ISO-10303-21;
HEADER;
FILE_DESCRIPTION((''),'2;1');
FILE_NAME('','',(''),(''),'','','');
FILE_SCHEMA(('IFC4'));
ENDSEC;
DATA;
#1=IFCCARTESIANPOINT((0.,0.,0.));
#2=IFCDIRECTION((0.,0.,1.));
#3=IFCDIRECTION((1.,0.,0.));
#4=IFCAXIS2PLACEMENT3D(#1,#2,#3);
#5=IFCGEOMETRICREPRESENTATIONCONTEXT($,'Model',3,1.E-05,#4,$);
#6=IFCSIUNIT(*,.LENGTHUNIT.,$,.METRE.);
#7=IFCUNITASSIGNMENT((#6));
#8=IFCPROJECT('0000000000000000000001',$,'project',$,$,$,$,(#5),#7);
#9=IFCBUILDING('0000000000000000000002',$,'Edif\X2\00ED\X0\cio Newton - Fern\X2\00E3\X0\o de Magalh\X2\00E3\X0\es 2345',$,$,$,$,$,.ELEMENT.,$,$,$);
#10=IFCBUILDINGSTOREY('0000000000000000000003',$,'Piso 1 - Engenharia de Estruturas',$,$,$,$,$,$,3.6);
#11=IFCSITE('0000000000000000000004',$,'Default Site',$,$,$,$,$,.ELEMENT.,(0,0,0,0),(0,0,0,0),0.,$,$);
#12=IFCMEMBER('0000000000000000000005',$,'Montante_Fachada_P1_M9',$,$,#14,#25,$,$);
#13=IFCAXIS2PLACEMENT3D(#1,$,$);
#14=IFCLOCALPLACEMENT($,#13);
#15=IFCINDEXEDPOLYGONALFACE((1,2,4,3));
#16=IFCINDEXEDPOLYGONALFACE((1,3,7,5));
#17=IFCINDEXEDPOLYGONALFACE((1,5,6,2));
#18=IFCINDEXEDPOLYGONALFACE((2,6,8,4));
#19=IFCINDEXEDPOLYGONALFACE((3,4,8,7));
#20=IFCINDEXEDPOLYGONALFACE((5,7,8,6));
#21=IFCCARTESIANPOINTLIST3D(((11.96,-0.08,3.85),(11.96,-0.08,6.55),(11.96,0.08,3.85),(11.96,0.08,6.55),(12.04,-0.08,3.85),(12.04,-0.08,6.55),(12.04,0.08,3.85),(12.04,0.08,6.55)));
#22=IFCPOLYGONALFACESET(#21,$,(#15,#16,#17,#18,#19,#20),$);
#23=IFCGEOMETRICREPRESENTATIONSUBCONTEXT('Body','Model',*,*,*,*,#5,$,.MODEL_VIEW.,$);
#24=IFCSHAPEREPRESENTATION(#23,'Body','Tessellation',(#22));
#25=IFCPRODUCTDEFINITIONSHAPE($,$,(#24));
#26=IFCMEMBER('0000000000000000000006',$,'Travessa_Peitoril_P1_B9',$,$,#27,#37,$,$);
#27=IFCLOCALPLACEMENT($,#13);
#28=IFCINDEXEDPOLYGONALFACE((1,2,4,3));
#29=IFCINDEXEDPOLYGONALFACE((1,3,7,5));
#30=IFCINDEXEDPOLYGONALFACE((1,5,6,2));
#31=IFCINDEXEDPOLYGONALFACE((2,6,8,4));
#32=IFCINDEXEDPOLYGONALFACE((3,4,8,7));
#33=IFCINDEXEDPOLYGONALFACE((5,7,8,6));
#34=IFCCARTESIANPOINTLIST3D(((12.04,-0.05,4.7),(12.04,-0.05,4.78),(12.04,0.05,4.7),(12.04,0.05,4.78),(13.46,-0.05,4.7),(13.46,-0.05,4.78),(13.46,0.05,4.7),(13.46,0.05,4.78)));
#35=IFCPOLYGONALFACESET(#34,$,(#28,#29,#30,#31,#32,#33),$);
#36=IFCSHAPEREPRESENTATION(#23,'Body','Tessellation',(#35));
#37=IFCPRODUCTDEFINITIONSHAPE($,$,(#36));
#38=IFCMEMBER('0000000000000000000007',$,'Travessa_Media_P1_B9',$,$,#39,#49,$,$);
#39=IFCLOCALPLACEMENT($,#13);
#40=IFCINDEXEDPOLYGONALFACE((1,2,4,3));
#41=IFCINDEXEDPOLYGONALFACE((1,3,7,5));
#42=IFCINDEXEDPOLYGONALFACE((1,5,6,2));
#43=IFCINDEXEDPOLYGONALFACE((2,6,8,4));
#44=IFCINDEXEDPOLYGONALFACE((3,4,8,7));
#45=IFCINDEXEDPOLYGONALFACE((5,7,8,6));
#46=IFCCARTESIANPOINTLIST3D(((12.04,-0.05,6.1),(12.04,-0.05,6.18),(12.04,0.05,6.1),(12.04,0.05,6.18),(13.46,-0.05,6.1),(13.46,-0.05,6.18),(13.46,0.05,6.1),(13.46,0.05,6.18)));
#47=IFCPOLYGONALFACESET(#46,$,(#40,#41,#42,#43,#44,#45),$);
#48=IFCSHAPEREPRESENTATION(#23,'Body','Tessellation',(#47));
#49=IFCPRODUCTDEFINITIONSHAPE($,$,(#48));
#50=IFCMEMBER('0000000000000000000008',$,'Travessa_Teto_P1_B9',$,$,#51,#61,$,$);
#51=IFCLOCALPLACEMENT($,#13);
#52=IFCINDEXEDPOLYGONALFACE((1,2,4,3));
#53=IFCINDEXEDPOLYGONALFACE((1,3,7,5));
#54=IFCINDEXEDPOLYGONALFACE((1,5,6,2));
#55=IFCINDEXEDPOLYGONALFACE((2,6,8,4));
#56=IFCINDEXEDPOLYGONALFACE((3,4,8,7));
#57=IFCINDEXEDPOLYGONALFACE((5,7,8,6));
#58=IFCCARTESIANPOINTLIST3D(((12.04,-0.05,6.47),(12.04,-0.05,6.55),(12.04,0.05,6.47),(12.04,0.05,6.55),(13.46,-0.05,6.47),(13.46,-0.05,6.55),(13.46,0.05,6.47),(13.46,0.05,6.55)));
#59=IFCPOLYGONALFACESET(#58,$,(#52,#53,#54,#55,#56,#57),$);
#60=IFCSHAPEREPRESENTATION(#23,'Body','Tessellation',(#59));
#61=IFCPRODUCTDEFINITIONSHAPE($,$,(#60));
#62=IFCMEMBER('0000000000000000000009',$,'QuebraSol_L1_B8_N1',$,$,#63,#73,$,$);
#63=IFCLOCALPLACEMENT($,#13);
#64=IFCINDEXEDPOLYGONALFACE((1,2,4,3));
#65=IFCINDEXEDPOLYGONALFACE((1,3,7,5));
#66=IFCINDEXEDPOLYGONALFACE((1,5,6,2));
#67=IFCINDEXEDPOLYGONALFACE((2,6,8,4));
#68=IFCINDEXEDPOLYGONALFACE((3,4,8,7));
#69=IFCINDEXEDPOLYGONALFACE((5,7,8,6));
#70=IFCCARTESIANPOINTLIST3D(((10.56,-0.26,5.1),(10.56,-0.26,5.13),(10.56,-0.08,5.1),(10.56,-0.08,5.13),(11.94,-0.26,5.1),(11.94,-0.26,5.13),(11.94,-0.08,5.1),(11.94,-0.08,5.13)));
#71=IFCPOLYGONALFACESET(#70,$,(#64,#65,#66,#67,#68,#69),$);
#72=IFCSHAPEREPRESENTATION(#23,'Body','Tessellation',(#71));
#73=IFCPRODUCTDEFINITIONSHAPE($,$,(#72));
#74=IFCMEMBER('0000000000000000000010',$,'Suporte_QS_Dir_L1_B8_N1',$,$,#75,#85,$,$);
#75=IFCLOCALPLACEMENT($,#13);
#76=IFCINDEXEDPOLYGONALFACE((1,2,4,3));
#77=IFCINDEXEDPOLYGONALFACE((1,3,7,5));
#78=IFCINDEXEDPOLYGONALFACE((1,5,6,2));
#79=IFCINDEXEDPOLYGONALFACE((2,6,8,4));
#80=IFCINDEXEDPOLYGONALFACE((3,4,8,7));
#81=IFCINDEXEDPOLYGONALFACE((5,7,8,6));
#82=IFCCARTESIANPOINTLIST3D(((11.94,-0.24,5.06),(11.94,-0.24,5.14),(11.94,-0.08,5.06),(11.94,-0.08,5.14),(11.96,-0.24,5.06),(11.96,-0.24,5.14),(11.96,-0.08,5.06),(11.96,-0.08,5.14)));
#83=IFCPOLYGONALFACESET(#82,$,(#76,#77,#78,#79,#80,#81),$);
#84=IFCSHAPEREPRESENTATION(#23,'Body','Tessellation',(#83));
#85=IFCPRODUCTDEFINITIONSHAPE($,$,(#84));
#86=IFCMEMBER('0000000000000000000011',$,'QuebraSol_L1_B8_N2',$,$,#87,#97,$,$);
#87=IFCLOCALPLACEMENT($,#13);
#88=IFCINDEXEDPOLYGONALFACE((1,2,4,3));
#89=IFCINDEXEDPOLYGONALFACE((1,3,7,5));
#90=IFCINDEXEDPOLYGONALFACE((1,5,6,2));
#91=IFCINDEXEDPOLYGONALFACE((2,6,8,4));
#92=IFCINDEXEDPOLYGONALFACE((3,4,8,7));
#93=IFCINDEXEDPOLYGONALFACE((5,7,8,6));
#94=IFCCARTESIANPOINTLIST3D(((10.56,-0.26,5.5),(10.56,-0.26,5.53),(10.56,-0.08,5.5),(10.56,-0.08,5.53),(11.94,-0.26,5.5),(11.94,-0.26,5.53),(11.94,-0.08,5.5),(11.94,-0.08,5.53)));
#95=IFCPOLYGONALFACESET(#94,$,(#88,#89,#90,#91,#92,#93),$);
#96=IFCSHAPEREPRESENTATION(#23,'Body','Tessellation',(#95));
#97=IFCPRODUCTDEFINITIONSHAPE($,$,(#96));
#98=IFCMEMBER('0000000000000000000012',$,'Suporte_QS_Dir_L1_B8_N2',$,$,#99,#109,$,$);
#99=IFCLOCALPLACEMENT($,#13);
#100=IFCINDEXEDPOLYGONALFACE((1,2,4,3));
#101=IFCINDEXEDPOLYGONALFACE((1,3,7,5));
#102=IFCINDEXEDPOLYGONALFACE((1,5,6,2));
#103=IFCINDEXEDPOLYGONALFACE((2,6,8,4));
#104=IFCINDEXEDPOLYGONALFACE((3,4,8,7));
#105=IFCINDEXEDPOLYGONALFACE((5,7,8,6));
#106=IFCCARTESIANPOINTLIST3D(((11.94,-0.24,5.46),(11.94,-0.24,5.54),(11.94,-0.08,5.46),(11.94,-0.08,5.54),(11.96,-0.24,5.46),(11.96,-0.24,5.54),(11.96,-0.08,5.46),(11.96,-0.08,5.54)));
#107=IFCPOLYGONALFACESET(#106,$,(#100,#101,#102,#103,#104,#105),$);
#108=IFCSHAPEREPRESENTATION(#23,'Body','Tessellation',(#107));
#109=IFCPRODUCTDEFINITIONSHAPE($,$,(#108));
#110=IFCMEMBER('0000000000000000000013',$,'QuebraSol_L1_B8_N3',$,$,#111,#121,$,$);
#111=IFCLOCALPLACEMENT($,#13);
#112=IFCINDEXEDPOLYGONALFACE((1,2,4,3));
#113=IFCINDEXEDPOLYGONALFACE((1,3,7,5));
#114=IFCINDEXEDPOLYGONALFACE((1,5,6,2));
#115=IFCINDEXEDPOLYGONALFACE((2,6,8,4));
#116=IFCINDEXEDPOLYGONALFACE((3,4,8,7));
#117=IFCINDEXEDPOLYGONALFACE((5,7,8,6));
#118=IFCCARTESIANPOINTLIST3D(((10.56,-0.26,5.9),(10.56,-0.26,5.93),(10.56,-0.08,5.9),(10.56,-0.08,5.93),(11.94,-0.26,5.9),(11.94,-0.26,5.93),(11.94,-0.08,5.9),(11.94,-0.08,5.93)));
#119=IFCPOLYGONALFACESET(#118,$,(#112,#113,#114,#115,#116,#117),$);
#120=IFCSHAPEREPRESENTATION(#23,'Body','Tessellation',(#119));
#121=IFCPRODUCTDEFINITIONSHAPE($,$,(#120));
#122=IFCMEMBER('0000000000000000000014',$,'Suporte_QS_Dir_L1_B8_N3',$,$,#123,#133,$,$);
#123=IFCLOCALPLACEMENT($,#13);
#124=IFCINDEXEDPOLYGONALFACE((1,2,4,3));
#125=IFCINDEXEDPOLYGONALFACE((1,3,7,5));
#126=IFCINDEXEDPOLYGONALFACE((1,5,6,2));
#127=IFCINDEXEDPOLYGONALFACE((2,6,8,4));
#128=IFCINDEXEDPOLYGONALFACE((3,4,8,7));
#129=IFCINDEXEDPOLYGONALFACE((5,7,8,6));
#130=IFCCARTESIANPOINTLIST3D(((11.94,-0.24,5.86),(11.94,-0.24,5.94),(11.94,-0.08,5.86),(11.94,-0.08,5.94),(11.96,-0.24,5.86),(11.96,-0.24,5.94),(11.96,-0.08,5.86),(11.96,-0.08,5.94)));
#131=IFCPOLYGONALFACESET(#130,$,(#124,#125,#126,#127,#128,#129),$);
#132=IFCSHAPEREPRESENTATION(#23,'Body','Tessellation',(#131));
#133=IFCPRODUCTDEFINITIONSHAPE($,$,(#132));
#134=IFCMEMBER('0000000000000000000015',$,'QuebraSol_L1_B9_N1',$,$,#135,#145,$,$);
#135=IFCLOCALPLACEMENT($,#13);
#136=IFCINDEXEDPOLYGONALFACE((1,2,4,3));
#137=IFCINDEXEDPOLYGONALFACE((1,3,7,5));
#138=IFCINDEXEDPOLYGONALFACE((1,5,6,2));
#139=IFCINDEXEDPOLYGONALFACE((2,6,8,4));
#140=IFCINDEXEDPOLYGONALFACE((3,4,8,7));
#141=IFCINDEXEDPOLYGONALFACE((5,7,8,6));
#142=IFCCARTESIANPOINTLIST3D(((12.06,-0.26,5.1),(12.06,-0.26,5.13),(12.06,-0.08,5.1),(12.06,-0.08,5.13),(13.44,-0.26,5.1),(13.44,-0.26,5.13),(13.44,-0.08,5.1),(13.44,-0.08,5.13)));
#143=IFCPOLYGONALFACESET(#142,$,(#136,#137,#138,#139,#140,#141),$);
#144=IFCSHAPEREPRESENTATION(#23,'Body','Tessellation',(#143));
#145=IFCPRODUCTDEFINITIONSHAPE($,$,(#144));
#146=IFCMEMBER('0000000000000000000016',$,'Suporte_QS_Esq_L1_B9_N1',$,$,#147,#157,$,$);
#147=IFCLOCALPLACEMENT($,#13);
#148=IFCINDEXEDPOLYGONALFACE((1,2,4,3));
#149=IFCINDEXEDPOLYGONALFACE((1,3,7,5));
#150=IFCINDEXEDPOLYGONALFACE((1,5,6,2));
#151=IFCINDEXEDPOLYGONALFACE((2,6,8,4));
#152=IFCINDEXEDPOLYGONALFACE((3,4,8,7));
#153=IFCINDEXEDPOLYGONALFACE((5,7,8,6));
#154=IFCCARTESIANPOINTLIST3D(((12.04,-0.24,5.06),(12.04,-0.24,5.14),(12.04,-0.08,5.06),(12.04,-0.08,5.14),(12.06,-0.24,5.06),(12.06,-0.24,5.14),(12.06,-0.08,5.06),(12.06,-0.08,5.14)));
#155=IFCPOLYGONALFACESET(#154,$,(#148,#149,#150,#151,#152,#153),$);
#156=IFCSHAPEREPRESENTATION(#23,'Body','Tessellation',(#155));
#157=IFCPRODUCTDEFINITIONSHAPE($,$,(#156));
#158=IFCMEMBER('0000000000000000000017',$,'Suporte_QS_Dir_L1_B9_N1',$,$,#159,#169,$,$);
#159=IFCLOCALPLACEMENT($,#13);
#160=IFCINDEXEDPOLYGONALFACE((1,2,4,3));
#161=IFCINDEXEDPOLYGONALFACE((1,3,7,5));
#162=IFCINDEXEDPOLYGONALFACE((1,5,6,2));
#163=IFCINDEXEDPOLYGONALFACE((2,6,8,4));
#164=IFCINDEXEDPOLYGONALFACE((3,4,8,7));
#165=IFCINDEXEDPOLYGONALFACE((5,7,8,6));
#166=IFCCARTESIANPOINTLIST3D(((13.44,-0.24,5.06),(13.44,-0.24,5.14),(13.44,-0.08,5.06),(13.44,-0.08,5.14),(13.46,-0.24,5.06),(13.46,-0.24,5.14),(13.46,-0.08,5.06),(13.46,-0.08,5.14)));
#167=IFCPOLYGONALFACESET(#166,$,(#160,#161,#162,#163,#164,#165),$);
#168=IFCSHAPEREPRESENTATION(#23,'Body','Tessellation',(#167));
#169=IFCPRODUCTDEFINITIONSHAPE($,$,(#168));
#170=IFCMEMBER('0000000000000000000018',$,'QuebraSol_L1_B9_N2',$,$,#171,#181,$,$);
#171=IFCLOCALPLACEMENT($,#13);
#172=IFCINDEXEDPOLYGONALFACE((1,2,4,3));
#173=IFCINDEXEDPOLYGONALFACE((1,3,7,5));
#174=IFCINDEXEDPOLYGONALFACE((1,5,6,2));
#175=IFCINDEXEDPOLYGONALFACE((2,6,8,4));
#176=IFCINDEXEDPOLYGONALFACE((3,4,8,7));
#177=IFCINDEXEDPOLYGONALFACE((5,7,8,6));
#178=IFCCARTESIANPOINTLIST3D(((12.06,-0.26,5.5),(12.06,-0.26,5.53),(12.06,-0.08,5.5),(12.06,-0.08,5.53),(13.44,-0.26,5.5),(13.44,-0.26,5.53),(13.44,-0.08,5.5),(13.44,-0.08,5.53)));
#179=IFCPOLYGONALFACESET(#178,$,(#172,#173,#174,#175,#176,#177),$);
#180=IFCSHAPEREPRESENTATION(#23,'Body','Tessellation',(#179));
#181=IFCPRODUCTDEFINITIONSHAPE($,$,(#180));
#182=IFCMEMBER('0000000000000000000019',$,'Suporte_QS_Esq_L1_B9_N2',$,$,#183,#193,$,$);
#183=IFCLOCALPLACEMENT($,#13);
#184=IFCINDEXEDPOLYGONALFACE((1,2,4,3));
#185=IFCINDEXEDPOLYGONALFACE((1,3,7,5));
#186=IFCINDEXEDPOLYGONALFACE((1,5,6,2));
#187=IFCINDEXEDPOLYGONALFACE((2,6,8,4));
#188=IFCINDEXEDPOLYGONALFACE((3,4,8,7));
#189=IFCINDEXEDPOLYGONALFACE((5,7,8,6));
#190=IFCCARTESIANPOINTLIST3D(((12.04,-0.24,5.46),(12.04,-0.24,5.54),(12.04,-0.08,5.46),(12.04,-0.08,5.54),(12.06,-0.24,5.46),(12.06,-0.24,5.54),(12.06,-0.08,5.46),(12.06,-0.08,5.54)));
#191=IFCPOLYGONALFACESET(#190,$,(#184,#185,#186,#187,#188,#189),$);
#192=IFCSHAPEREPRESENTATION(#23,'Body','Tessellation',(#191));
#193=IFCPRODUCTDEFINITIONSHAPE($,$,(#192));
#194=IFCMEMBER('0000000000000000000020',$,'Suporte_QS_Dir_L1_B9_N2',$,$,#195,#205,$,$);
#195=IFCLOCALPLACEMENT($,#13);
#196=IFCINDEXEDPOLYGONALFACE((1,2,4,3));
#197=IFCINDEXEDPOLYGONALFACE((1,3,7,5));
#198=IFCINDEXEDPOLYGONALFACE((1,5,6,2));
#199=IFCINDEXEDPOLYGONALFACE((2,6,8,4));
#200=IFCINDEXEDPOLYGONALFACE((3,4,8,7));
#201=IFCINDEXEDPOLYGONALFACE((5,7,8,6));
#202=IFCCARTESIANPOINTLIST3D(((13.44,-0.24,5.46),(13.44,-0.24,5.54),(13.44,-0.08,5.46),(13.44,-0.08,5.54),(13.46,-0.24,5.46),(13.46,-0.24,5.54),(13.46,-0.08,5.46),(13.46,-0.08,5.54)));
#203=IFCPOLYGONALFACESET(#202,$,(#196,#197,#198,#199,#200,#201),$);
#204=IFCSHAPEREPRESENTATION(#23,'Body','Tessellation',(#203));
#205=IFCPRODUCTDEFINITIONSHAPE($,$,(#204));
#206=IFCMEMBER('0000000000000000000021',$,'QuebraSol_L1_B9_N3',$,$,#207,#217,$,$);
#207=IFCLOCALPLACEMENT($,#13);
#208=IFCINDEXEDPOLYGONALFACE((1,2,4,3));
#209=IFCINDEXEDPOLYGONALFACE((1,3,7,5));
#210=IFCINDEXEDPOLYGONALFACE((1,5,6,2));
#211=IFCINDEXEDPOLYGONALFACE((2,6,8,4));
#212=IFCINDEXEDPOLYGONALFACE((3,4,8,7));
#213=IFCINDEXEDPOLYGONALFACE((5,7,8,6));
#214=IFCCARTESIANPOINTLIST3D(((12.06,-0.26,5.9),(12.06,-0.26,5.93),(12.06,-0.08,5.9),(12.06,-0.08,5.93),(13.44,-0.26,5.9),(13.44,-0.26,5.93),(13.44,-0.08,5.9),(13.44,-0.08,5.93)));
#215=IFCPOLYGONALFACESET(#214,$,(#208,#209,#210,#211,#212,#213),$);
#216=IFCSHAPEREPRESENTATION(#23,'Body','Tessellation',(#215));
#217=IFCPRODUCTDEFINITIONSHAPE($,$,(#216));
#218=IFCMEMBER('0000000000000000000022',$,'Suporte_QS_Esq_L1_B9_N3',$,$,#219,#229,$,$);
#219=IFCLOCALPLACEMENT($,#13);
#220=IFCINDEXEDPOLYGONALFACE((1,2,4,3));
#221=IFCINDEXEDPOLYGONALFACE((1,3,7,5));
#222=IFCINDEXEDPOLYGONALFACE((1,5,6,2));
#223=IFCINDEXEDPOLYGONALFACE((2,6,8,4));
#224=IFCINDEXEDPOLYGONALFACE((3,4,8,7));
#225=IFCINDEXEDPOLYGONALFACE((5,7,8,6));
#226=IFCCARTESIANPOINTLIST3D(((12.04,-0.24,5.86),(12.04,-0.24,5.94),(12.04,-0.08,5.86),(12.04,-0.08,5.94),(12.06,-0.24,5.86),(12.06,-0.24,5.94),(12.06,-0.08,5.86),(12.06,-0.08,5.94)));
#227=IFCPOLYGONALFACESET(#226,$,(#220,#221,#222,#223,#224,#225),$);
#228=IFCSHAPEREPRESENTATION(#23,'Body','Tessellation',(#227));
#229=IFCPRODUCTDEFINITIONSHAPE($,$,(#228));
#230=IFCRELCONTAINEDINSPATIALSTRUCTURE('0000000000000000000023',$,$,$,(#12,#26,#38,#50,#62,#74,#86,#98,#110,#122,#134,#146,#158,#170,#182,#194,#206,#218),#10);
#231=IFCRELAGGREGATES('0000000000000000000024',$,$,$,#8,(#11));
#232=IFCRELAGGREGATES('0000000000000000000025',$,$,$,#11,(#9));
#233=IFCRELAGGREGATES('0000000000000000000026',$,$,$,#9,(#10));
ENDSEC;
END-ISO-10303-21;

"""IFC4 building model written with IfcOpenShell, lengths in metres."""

from ifc_helpers import new_model, si_unit, frame, frame_2d, origin_with_axes, place, context, subcontext, project, spatial, rectangle, extrude, element, save


model = new_model("IFC4")

# Units and contexts
model_context = context("Model", 3, precision=1e-05, world=origin_with_axes())
body_context = subcontext(model_context, "Body", "Model", "MODEL_VIEW")
ifc_project = project(units=[si_unit("LENGTHUNIT", "METRE")], contexts=[model_context])

# Site, building, storey
site = spatial("IfcSite", under=ifc_project, Name="Default Site", CompositionType="ELEMENT", RefLatitude=(0, 0, 0, 0), RefLongitude=(0, 0, 0, 0), RefElevation=0.0)
building = spatial("IfcBuilding", under=site, Name="Edifício Newton - Fernão de Magalhães 2345", CompositionType="ELEMENT")
storey = spatial("IfcBuildingStorey", under=building, Name="Piso 1 - Engenharia de Estruturas", Elevation=3.6)

# Members
member_1_placement = place(None, frame((11.96, -0.08, 3.85), z_axis=(0.0, 0.0, 1.0), x_axis=(1.0, 0.0, 0.0)))
element("IfcMember", 1, at=member_1_placement, inside=storey, Name="Montante_Fachada_P1_M9", context=body_context, shape_type="SweptSolid", body=[
    extrude(rectangle(XDim=0.08, YDim=0.16, at=frame_2d((0.04, 0.08))), origin_with_axes(), (0.0, 0.0, 1.0), 2.7),
])
for number, where, z_axis, x_axis, name in (
    (2, (12.04, -0.05, 4.7), (0.0, 0.0, 1.0), (1.0, 0.0, 0.0), "Travessa_Peitoril_P1_B9"),
    (3, (12.04, -0.05, 6.1), (0.0, 0.0, 1.0), (1.0, 0.0, 0.0), "Travessa_Media_P1_B9"),
    (4, (12.04, -0.05, 6.47), (0.0, 0.0, 1.0), (1.0, 0.0, 0.0), "Travessa_Teto_P1_B9"),
):
    element("IfcMember", number, at=place(None, frame(where, z_axis=z_axis, x_axis=x_axis)), inside=storey, Name=name, context=body_context, shape_type="SweptSolid", body=[
        extrude(rectangle(XDim=1.42, YDim=0.1, at=frame_2d((0.71, 0.05))), origin_with_axes(), (0.0, 0.0, 1.0), 0.08),
    ])
member_2_placement = place(None, frame((10.56, -0.26, 5.1), z_axis=(0.0, 0.0, 1.0), x_axis=(1.0, 0.0, 0.0)))
element("IfcMember", 5, at=member_2_placement, inside=storey, Name="QuebraSol_L1_B8_N1", context=body_context, shape_type="SweptSolid", body=[
    extrude(rectangle(XDim=1.38, YDim=0.18, at=frame_2d((0.69, 0.09))), origin_with_axes(), (0.0, 0.0, 1.0), 0.03),
])
member_3_placement = place(None, frame((11.94, -0.24, 5.06), z_axis=(0.0, 0.0, 1.0), x_axis=(1.0, 0.0, 0.0)))
element("IfcMember", 6, at=member_3_placement, inside=storey, Name="Suporte_QS_Dir_L1_B8_N1", context=body_context, shape_type="SweptSolid", body=[
    extrude(rectangle(XDim=0.02, YDim=0.16, at=frame_2d((0.01, 0.08))), origin_with_axes(), (0.0, 0.0, 1.0), 0.08),
])
member_4_placement = place(None, frame((10.56, -0.26, 5.5), z_axis=(0.0, 0.0, 1.0), x_axis=(1.0, 0.0, 0.0)))
element("IfcMember", 7, at=member_4_placement, inside=storey, Name="QuebraSol_L1_B8_N2", context=body_context, shape_type="SweptSolid", body=[
    extrude(rectangle(XDim=1.38, YDim=0.18, at=frame_2d((0.69, 0.09))), origin_with_axes(), (0.0, 0.0, 1.0), 0.03),
])
member_5_placement = place(None, frame((11.94, -0.24, 5.46), z_axis=(0.0, 0.0, 1.0), x_axis=(1.0, 0.0, 0.0)))
element("IfcMember", 8, at=member_5_placement, inside=storey, Name="Suporte_QS_Dir_L1_B8_N2", context=body_context, shape_type="SweptSolid", body=[
    extrude(rectangle(XDim=0.02, YDim=0.16, at=frame_2d((0.01, 0.08))), origin_with_axes(), (0.0, 0.0, 1.0), 0.08),
])
member_6_placement = place(None, frame((10.56, -0.26, 5.9), z_axis=(0.0, 0.0, 1.0), x_axis=(1.0, 0.0, 0.0)))
element("IfcMember", 9, at=member_6_placement, inside=storey, Name="QuebraSol_L1_B8_N3", context=body_context, shape_type="SweptSolid", body=[
    extrude(rectangle(XDim=1.38, YDim=0.18, at=frame_2d((0.69, 0.09))), origin_with_axes(), (0.0, 0.0, 1.0), 0.03),
])
member_7_placement = place(None, frame((11.94, -0.24, 5.86), z_axis=(0.0, 0.0, 1.0), x_axis=(1.0, 0.0, 0.0)))
element("IfcMember", 10, at=member_7_placement, inside=storey, Name="Suporte_QS_Dir_L1_B8_N3", context=body_context, shape_type="SweptSolid", body=[
    extrude(rectangle(XDim=0.02, YDim=0.16, at=frame_2d((0.01, 0.08))), origin_with_axes(), (0.0, 0.0, 1.0), 0.08),
])
member_8_placement = place(None, frame((12.06, -0.26, 5.1), z_axis=(0.0, 0.0, 1.0), x_axis=(1.0, 0.0, 0.0)))
element("IfcMember", 11, at=member_8_placement, inside=storey, Name="QuebraSol_L1_B9_N1", context=body_context, shape_type="SweptSolid", body=[
    extrude(rectangle(XDim=1.38, YDim=0.18, at=frame_2d((0.69, 0.09))), origin_with_axes(), (0.0, 0.0, 1.0), 0.03),
])
for number, where, z_axis, x_axis, name in (
    (12, (12.04, -0.24, 5.06), (0.0, 0.0, 1.0), (1.0, 0.0, 0.0), "Suporte_QS_Esq_L1_B9_N1"),
    (13, (13.44, -0.24, 5.06), (0.0, 0.0, 1.0), (1.0, 0.0, 0.0), "Suporte_QS_Dir_L1_B9_N1"),
):
    element("IfcMember", number, at=place(None, frame(where, z_axis=z_axis, x_axis=x_axis)), inside=storey, Name=name, context=body_context, shape_type="SweptSolid", body=[
        extrude(rectangle(XDim=0.02, YDim=0.16, at=frame_2d((0.01, 0.08))), origin_with_axes(), (0.0, 0.0, 1.0), 0.08),
    ])
member_9_placement = place(None, frame((12.06, -0.26, 5.5), z_axis=(0.0, 0.0, 1.0), x_axis=(1.0, 0.0, 0.0)))
element("IfcMember", 14, at=member_9_placement, inside=storey, Name="QuebraSol_L1_B9_N2", context=body_context, shape_type="SweptSolid", body=[
    extrude(rectangle(XDim=1.38, YDim=0.18, at=frame_2d((0.69, 0.09))), origin_with_axes(), (0.0, 0.0, 1.0), 0.03),
])
for number, where, z_axis, x_axis, name in (
    (15, (12.04, -0.24, 5.46), (0.0, 0.0, 1.0), (1.0, 0.0, 0.0), "Suporte_QS_Esq_L1_B9_N2"),
    (16, (13.44, -0.24, 5.46), (0.0, 0.0, 1.0), (1.0, 0.0, 0.0), "Suporte_QS_Dir_L1_B9_N2"),
):
    element("IfcMember", number, at=place(None, frame(where, z_axis=z_axis, x_axis=x_axis)), inside=storey, Name=name, context=body_context, shape_type="SweptSolid", body=[
        extrude(rectangle(XDim=0.02, YDim=0.16, at=frame_2d((0.01, 0.08))), origin_with_axes(), (0.0, 0.0, 1.0), 0.08),
    ])
member_10_placement = place(None, frame((12.06, -0.26, 5.9), z_axis=(0.0, 0.0, 1.0), x_axis=(1.0, 0.0, 0.0)))
element("IfcMember", 17, at=member_10_placement, inside=storey, Name="QuebraSol_L1_B9_N3", context=body_context, shape_type="SweptSolid", body=[
    extrude(rectangle(XDim=1.38, YDim=0.18, at=frame_2d((0.69, 0.09))), origin_with_axes(), (0.0, 0.0, 1.0), 0.03),
])
member_11_placement = place(None, frame((12.04, -0.24, 5.86), z_axis=(0.0, 0.0, 1.0), x_axis=(1.0, 0.0, 0.0)))
element("IfcMember", 18, at=member_11_placement, inside=storey, Name="Suporte_QS_Esq_L1_B9_N3", context=body_context, shape_type="SweptSolid", body=[
    extrude(rectangle(XDim=0.02, YDim=0.16, at=frame_2d((0.01, 0.08))), origin_with_axes(), (0.0, 0.0, 1.0), 0.08),
])

save(model, "model.ifc")
